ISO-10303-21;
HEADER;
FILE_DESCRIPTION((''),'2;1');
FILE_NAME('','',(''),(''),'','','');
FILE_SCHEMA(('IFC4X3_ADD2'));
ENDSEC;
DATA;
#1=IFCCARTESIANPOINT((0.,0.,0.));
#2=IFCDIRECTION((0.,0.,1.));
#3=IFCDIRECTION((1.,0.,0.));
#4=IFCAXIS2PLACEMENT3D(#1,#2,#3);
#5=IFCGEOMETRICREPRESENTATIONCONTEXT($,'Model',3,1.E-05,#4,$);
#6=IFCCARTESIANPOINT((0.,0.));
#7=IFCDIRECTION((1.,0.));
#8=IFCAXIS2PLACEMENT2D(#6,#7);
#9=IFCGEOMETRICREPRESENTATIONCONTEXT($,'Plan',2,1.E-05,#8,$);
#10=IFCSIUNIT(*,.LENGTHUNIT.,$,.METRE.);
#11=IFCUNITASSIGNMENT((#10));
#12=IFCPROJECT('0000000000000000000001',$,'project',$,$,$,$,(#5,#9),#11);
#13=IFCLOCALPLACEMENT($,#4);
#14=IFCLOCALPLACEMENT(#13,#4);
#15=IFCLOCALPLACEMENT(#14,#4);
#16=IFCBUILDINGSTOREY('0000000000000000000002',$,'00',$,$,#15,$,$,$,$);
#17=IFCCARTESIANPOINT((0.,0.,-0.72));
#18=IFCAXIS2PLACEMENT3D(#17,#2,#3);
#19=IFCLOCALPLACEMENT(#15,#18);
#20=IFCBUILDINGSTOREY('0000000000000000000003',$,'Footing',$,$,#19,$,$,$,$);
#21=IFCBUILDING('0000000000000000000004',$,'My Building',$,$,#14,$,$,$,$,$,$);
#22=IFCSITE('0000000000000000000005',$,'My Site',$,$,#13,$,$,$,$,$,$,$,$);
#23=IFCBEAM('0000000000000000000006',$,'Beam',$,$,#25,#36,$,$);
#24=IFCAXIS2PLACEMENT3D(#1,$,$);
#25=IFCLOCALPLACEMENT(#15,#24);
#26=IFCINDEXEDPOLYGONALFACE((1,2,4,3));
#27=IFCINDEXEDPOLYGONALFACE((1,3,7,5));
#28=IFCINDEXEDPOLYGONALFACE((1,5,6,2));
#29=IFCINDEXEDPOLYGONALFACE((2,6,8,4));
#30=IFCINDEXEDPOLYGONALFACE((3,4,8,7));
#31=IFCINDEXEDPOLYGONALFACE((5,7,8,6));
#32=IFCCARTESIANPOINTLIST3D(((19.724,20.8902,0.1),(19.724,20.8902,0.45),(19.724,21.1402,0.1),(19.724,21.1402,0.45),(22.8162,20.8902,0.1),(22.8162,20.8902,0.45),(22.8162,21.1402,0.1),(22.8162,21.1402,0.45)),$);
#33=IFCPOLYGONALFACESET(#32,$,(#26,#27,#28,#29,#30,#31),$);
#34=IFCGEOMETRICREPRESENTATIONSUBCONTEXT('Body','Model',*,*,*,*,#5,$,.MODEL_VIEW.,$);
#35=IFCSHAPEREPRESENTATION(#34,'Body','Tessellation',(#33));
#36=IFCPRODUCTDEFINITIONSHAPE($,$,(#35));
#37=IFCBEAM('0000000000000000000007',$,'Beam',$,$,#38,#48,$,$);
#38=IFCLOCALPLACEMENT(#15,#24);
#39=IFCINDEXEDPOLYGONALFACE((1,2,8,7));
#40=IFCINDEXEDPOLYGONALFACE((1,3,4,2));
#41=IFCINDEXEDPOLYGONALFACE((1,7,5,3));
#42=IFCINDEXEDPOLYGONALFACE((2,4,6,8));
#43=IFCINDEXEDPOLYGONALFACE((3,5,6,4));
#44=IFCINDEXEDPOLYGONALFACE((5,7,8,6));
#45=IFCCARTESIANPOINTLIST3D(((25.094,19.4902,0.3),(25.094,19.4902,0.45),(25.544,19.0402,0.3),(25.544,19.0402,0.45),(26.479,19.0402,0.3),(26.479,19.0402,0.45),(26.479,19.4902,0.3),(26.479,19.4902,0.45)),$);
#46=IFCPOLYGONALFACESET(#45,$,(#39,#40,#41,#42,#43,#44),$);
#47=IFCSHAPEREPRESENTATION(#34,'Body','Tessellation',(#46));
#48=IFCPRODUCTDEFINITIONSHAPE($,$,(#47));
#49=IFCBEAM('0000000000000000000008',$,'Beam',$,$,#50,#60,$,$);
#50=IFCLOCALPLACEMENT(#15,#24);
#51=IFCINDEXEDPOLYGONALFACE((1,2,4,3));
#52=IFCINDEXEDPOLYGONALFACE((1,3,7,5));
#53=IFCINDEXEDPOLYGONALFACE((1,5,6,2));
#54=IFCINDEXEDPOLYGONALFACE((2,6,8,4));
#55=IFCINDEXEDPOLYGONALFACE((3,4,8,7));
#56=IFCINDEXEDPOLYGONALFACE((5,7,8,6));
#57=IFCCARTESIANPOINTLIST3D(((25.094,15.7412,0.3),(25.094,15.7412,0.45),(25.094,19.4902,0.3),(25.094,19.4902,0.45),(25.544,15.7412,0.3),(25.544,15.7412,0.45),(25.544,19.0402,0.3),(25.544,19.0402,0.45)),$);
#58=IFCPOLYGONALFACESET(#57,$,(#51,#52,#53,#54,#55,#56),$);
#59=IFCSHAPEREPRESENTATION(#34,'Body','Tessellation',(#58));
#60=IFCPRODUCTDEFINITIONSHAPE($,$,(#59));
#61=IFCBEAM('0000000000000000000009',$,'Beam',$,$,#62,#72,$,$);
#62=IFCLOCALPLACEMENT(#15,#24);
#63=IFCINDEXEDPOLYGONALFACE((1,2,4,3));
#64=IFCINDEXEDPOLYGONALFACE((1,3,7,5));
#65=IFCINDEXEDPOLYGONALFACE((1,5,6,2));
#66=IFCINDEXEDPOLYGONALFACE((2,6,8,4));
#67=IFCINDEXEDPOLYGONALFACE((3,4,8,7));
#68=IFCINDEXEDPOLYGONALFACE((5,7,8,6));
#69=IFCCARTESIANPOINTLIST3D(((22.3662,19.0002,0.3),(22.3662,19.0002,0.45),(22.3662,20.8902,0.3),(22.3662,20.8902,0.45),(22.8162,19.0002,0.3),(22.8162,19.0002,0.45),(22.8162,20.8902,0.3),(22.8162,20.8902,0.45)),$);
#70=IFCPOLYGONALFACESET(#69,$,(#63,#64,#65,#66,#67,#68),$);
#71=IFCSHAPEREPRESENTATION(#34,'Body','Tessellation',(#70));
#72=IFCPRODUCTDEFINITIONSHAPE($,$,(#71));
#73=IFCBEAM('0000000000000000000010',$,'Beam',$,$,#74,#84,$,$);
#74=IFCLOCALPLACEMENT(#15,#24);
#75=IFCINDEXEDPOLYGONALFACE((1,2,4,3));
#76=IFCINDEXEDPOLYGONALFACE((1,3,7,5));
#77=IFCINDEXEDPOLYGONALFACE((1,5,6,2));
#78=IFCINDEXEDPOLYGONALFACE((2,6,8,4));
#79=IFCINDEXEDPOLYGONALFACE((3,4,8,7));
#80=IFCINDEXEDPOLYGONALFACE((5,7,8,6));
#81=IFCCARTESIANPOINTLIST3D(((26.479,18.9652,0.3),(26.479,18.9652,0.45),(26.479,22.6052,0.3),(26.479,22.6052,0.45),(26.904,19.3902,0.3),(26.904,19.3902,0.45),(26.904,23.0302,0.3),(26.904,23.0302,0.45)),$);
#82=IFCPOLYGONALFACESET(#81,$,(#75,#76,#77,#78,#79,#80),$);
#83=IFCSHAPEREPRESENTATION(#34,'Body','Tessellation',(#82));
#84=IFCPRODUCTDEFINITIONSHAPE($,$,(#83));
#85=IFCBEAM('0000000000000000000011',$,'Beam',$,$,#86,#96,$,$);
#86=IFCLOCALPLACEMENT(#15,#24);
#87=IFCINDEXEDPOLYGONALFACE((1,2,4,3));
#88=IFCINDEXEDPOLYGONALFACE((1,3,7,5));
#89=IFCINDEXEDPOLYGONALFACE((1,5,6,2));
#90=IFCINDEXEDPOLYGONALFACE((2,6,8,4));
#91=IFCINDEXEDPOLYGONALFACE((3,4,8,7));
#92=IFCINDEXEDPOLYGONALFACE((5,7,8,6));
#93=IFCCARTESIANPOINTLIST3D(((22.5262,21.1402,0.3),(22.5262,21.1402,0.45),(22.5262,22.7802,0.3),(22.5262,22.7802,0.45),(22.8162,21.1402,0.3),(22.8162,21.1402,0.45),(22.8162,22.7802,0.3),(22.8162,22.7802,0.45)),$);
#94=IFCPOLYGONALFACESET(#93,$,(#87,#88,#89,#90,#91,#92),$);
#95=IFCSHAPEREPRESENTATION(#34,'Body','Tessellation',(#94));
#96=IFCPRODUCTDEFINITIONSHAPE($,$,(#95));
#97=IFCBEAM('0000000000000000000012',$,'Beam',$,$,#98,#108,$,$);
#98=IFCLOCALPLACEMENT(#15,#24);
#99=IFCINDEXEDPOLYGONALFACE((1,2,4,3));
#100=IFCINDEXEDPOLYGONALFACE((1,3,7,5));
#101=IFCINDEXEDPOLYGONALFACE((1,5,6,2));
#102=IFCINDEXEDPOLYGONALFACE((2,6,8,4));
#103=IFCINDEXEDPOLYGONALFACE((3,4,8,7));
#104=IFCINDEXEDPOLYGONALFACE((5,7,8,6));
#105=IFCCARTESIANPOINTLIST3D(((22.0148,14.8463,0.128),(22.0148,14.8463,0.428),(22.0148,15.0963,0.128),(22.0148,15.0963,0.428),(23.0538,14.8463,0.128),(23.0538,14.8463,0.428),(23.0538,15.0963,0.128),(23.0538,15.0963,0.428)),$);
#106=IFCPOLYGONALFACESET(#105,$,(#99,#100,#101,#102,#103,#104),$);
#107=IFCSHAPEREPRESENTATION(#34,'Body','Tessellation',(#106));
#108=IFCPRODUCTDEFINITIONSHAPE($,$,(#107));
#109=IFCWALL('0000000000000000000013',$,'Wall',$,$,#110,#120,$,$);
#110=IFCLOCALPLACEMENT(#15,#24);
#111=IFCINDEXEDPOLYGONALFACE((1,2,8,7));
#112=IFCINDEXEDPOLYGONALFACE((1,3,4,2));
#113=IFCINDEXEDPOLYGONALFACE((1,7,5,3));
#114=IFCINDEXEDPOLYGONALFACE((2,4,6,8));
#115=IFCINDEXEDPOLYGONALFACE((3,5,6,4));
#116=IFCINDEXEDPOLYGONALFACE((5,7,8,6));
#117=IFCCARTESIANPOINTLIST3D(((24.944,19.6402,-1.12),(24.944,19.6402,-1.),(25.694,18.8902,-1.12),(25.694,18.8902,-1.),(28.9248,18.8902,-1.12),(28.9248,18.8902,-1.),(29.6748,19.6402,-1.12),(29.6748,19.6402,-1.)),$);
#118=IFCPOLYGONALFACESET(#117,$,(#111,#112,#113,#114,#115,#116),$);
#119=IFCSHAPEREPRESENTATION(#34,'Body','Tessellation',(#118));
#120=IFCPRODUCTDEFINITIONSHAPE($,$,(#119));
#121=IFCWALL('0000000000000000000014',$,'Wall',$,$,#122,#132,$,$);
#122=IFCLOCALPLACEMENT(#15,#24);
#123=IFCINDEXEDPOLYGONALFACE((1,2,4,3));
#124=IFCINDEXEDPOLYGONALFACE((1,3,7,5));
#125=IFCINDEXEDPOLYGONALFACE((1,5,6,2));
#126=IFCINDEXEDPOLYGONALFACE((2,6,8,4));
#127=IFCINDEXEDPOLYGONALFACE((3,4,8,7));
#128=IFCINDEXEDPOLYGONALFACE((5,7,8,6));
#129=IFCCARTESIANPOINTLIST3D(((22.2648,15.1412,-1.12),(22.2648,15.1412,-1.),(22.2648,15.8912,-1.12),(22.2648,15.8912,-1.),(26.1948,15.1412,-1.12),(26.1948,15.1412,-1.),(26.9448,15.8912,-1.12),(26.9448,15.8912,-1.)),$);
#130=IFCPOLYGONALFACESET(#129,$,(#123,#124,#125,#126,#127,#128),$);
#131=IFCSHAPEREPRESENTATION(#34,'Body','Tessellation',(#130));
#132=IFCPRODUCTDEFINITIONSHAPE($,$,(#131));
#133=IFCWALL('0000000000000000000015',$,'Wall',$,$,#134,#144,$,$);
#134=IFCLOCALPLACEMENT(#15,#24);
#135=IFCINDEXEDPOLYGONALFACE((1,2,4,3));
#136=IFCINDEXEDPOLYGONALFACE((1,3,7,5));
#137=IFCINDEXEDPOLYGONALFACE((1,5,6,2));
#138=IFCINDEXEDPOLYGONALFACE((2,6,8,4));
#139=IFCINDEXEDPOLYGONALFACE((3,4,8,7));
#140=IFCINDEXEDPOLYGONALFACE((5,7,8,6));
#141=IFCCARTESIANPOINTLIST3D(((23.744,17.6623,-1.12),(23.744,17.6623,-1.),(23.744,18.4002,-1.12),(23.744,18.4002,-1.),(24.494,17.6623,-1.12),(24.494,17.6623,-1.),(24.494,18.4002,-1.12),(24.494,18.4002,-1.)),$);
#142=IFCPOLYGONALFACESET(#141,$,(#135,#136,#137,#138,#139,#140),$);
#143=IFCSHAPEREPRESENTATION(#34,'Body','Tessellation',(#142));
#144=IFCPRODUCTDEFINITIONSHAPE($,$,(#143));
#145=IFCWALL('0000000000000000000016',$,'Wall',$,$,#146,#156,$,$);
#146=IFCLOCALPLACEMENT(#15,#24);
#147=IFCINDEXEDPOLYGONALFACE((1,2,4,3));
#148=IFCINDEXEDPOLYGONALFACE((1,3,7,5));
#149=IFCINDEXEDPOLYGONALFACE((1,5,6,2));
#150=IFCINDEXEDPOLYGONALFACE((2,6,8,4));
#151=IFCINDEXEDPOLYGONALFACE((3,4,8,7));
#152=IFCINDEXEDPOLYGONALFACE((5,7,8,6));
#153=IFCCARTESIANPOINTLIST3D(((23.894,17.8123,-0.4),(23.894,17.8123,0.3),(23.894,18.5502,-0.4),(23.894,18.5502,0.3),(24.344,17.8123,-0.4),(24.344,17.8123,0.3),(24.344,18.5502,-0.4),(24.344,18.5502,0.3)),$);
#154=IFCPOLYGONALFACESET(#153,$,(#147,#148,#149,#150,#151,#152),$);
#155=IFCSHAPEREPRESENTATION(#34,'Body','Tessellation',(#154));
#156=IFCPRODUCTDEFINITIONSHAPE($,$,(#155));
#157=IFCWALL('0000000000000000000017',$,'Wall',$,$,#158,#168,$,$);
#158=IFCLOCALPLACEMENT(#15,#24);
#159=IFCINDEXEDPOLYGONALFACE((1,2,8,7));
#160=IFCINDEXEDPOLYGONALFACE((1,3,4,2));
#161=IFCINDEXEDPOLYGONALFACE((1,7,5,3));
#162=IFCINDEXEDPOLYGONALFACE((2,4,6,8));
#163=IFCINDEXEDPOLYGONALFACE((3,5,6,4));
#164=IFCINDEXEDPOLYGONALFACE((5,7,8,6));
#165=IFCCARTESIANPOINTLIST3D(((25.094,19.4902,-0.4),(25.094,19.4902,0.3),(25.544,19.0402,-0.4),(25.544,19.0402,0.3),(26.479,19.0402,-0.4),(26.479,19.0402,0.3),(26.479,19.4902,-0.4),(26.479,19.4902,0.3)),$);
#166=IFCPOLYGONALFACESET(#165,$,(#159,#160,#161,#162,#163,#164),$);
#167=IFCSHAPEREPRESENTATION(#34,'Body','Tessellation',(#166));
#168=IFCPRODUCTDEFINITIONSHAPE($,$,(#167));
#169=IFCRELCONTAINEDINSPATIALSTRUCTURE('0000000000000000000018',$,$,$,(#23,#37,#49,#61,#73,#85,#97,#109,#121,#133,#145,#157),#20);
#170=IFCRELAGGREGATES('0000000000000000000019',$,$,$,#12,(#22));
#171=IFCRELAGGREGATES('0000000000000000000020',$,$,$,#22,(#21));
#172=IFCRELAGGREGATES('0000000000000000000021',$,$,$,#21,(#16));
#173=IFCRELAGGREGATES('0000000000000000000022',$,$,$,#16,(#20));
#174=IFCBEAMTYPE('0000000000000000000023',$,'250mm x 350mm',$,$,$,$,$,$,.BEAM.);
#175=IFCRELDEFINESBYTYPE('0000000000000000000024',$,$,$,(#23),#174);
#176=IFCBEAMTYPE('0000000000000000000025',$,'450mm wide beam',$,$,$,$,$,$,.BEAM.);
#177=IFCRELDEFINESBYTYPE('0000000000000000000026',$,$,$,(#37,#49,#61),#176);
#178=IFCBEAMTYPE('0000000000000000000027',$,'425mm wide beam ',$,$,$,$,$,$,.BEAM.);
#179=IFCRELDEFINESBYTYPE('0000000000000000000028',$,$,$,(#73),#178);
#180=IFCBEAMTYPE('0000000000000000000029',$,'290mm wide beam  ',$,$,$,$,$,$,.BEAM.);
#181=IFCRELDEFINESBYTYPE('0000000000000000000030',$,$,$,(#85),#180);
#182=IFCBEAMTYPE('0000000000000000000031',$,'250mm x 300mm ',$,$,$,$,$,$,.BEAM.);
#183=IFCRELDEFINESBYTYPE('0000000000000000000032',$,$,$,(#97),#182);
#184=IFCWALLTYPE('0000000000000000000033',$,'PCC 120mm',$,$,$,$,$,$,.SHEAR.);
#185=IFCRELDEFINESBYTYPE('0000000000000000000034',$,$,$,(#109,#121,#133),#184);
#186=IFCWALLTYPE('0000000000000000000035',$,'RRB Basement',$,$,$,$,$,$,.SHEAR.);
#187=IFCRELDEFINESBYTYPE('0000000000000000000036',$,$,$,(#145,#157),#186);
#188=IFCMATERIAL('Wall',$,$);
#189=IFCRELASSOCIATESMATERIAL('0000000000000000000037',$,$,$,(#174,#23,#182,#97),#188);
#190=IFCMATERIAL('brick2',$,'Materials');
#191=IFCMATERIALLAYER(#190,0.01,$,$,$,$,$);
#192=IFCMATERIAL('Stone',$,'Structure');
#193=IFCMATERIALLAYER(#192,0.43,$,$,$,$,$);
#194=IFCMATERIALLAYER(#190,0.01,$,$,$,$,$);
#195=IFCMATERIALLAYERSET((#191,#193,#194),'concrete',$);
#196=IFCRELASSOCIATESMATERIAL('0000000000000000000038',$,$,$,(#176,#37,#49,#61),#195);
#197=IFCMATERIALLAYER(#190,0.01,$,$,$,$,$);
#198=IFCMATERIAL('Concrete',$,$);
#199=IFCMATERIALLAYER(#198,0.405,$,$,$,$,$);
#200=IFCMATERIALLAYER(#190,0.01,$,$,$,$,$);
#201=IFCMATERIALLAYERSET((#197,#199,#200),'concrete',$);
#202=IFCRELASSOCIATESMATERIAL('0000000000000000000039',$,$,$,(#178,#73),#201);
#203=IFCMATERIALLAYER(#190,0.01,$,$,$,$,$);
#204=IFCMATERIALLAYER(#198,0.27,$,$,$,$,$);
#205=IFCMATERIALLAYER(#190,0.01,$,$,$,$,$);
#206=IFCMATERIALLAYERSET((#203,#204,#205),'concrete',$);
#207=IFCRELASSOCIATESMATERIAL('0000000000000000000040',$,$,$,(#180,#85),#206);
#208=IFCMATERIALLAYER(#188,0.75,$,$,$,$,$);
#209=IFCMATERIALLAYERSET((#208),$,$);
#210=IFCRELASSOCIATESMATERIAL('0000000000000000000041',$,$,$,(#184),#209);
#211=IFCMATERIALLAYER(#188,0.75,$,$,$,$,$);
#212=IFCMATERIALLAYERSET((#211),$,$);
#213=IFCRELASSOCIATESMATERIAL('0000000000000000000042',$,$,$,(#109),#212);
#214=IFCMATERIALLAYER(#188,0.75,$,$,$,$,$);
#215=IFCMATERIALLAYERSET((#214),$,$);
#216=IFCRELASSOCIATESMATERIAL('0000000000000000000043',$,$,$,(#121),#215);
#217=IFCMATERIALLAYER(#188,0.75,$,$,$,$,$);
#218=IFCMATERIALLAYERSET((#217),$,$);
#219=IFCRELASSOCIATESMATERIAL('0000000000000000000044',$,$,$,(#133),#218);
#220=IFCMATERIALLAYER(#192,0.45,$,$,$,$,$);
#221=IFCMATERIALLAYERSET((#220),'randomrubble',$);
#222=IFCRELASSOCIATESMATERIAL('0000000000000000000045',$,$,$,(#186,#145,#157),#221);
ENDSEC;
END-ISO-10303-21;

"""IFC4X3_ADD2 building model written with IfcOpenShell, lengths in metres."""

from ifc_helpers import new_model, si_unit, frame, origin_with_axes, origin_2d_with_axis, place, context, subcontext, project, spatial, line, indexed_curve, rectangle, outline, extrude, material, layer, layer_set, layer_usage, material_profile, profile_set, profile_usage, type_object, element, save


model = new_model("IFC4X3_ADD2")

# Units and contexts
model_context = context("Model", 3, precision=1e-05, world=origin_with_axes())
plan_context = context("Plan", 2, precision=1e-05, world=origin_2d_with_axis())
body_context = subcontext(model_context, "Body", "Model", "MODEL_VIEW")
ifc_project = project(units=[si_unit("LENGTHUNIT", "METRE")], contexts=[model_context, plan_context])

# Site, building, storeys
site_placement = place(None, origin_with_axes())
site = spatial("IfcSite", under=ifc_project, at=site_placement, Name="My Site")
building_placement = place(site_placement, origin_with_axes())
building = spatial("IfcBuilding", under=site, at=building_placement, Name="My Building")
storey_1_placement = place(building_placement, origin_with_axes())
storey_1 = spatial("IfcBuildingStorey", under=building, at=storey_1_placement, Name="00")
storey_2_placement = place(storey_1_placement, frame((0.0, 0.0, -0.72), z_axis=(0.0, 0.0, 1.0), x_axis=(1.0, 0.0, 0.0)))
storey_2 = spatial("IfcBuildingStorey", under=storey_1, at=storey_2_placement, Name="Footing")

# Beams
ifc_material_1 = material(Name="Wall")
ifc_material_profile_1 = material_profile(ifc_material_1, rectangle(XDim=0.25, YDim=0.35))
ifc_profile_set_1 = profile_set([ifc_material_profile_1], Name="concrete")
ifc_profile_usage_1 = profile_usage(ifc_profile_set_1, cardinal=5)
beam_type_1 = type_object("IfcBeamType", Name="250mm x 350mm", PredefinedType="BEAM", material=ifc_profile_set_1)
beam_1_placement = place(storey_2_placement, frame((22.8162, 21.0152, 0.995), z_axis=(-1.0, -0.000001, 0.000001), x_axis=(0.000001, -1.0, 0.0)))
element("IfcBeam", 1, at=beam_1_placement, inside=storey_2, type_object=beam_type_1, material=ifc_profile_usage_1, Name="Beam", context=body_context, shape_type="SweptSolid", body=[
    extrude(rectangle(XDim=0.25, YDim=0.35), origin_with_axes(), (0.0, 0.0, 1.0), 3.0922),
])
ifc_material_2 = material(Name="brick2", Category="Materials")
ifc_layer_1 = layer(ifc_material_2, 0.01)
ifc_material_3 = material(Name="Stone", Category="Structure")
ifc_layer_2 = layer(ifc_material_3, 0.43)
ifc_layer_3 = layer(ifc_material_2, 0.01)
ifc_layer_set_1 = layer_set([ifc_layer_1, ifc_layer_2, ifc_layer_3], Name="concrete")
ifc_layer_usage_1 = layer_usage(ifc_layer_set_1, "AXIS2", "NEGATIVE", 0.0)
beam_type_2 = type_object("IfcBeamType", Name="450mm wide beam", PredefinedType="BEAM", material=ifc_layer_set_1)
beam_2_placement = place(storey_2_placement, frame((25.544, 19.4902, 1.02), z_axis=(0.0, 0.0, 1.0), x_axis=(1.0, 0.0, 0.0)))
element("IfcBeam", 2, at=beam_2_placement, inside=storey_2, type_object=beam_type_2, material=ifc_layer_usage_1, Name="Beam", context=body_context, shape_type="SweptSolid", body=[
    extrude(outline(indexed_curve([(0.0, -0.45), (-0.45, 0.0), (0.935, 0.0), (0.935, -0.45)], segments=[line(1, 2, 3, 4, 1)])), origin_with_axes(), (0.0, 0.0, 1.0), 0.15),
])
ifc_layer_usage_2 = layer_usage(ifc_layer_set_1, "AXIS2", "NEGATIVE", 0.0)
beam_3_placement = place(storey_2_placement, frame((25.544, 19.4902, 1.02), z_axis=(0.0, 0.0, 1.0), x_axis=(0.0, -1.0, 0.0)))
element("IfcBeam", 3, at=beam_3_placement, inside=storey_2, type_object=beam_type_2, material=ifc_layer_usage_2, Name="Beam", context=body_context, shape_type="SweptSolid", body=[
    extrude(outline(indexed_curve([(0.0, -0.45), (0.45, 0.0), (3.749, 0.0), (3.749, -0.45)], segments=[line(1, 2, 3, 4, 1)])), origin_with_axes(), (0.0, 0.0, 1.0), 0.15),
])
ifc_layer_usage_3 = layer_usage(ifc_layer_set_1, "AXIS2", "POSITIVE", 0.0)
beam_4_placement = place(storey_2_placement, frame((22.3662, 20.8902, 1.02), z_axis=(0.0, 0.0, 1.0), x_axis=(0.0, -1.0, 0.0)))
element("IfcBeam", 4, at=beam_4_placement, inside=storey_2, type_object=beam_type_2, material=ifc_layer_usage_3, Name="Beam", context=body_context, shape_type="SweptSolid", body=[
    extrude(outline(indexed_curve([(0.0, 0.0), (0.0, 0.45), (1.89, 0.45), (1.89, 0.0)], segments=[line(1, 2, 3, 4, 1)])), origin_with_axes(), (0.0, 0.0, 1.0), 0.15),
])
ifc_layer_4 = layer(ifc_material_2, 0.01)
ifc_material_4 = material(Name="Concrete")
ifc_layer_5 = layer(ifc_material_4, 0.405)
ifc_layer_6 = layer(ifc_material_2, 0.01)
ifc_layer_set_2 = layer_set([ifc_layer_4, ifc_layer_5, ifc_layer_6], Name="concrete")
ifc_layer_usage_4 = layer_usage(ifc_layer_set_2, "AXIS2", "POSITIVE", 0.0)
beam_type_3 = type_object("IfcBeamType", Name="425mm wide beam ", PredefinedType="BEAM", material=ifc_layer_set_2)
beam_5_placement = place(storey_2_placement, frame((26.479, 22.6052, 1.02), z_axis=(0.0, 0.0, 1.0), x_axis=(0.0, -1.0, 0.0)))
element("IfcBeam", 5, at=beam_5_placement, inside=storey_2, type_object=beam_type_3, material=ifc_layer_usage_4, Name="Beam", context=body_context, shape_type="SweptSolid", body=[
    extrude(outline(indexed_curve([(0.0, 0.0), (-0.425, 0.425), (3.215, 0.425), (3.64, 0.0)], segments=[line(1, 2, 3, 4, 1)])), origin_with_axes(), (0.0, 0.0, 1.0), 0.15),
])
ifc_layer_7 = layer(ifc_material_2, 0.01)
ifc_layer_8 = layer(ifc_material_4, 0.27)
ifc_layer_9 = layer(ifc_material_2, 0.01)
ifc_layer_set_3 = layer_set([ifc_layer_7, ifc_layer_8, ifc_layer_9], Name="concrete")
ifc_layer_usage_5 = layer_usage(ifc_layer_set_3, "AXIS2", "POSITIVE", 0.0)
beam_type_4 = type_object("IfcBeamType", Name="290mm wide beam  ", PredefinedType="BEAM", material=ifc_layer_set_3)
beam_6_placement = place(storey_2_placement, frame((22.5262, 22.7802, 1.02), z_axis=(0.0, 0.0, 1.0), x_axis=(0.0, -1.0, 0.0)))
element("IfcBeam", 6, at=beam_6_placement, inside=storey_2, type_object=beam_type_4, material=ifc_layer_usage_5, Name="Beam", context=body_context, shape_type="SweptSolid", body=[
    extrude(outline(indexed_curve([(0.0, 0.0), (0.0, 0.29), (1.64, 0.29), (1.64, 0.0)], segments=[line(1, 2, 3, 4, 1)])), origin_with_axes(), (0.0, 0.0, 1.0), 0.15),
])
ifc_material_profile_2 = material_profile(ifc_material_1, rectangle(XDim=0.25, YDim=0.3))
ifc_profile_set_2 = profile_set([ifc_material_profile_2], Name="concrete")
ifc_profile_usage_2 = profile_usage(ifc_profile_set_2)
beam_type_5 = type_object("IfcBeamType", Name="250mm x 300mm ", PredefinedType="BEAM", material=ifc_profile_set_2)
beam_7_placement = place(storey_2_placement, frame((23.0538, 14.9713, 0.998), z_axis=(-1.0, -0.000001, 0.000001), x_axis=(0.000001, -1.0, 0.0)))
element("IfcBeam", 7, at=beam_7_placement, inside=storey_2, type_object=beam_type_5, material=ifc_profile_usage_2, Name="Beam", context=body_context, shape_type="SweptSolid", body=[
    extrude(rectangle(XDim=0.25, YDim=0.3), origin_with_axes(), (0.0, 0.0, 1.0), 1.039),
])

# Walls
ifc_layer_10 = layer(ifc_material_1, 0.75)
ifc_layer_set_4 = layer_set([ifc_layer_10])
ifc_layer_usage_6 = layer_usage(ifc_layer_set_4, "AXIS2", "POSITIVE", 0.0)
ifc_layer_11 = layer(ifc_material_1, 0.75)
ifc_layer_set_5 = layer_set([ifc_layer_11])
wall_type_1 = type_object("IfcWallType", Name="PCC 120mm", PredefinedType="SHEAR", material=ifc_layer_set_5)
wall_1_placement = place(storey_2_placement, frame((25.694, 18.8902, -0.4), z_axis=(0.0, 0.0, 1.0), x_axis=(1.0, 0.0, 0.0)))
element("IfcWall", 8, at=wall_1_placement, inside=storey_2, type_object=wall_type_1, material=ifc_layer_usage_6, Name="Wall", context=body_context, shape_type="SweptSolid", body=[
    extrude(outline(indexed_curve([(0.0, 0.0), (-0.75, 0.75), (3.9808, 0.75), (3.2308, 0.0)], segments=[line(1, 2, 3, 4, 1)])), origin_with_axes(), (0.0, 0.0, 1.0), 0.12),
])
ifc_layer_12 = layer(ifc_material_1, 0.75)
ifc_layer_set_6 = layer_set([ifc_layer_12])
ifc_layer_usage_7 = layer_usage(ifc_layer_set_6, "AXIS2", "POSITIVE", 0.0)
wall_2_placement = place(storey_2_placement, frame((22.2648, 15.1412, -0.4), z_axis=(0.0, 0.0, 1.0), x_axis=(1.0, 0.0, 0.0)))
element("IfcWall", 9, at=wall_2_placement, inside=storey_2, type_object=wall_type_1, material=ifc_layer_usage_7, Name="Wall", context=body_context, shape_type="SweptSolid", body=[
    extrude(outline(indexed_curve([(0.0, 0.0), (0.0, 0.75), (4.68, 0.75), (3.93, 0.0)], segments=[line(1, 2, 3, 4, 1)])), origin_with_axes(), (0.0, 0.0, 1.0), 0.12),
])
ifc_layer_13 = layer(ifc_material_1, 0.75)
ifc_layer_set_7 = layer_set([ifc_layer_13])
ifc_layer_usage_8 = layer_usage(ifc_layer_set_7, "AXIS2", "NEGATIVE", 0.0)
wall_3_placement = place(storey_2_placement, frame((23.744, 17.6623, -0.4), z_axis=(0.0, 0.0, 1.0), x_axis=(0.000001, 1.0, 0.0)))
element("IfcWall", 10, at=wall_3_placement, inside=storey_2, type_object=wall_type_1, material=ifc_layer_usage_8, Name="Wall", context=body_context, shape_type="SweptSolid", body=[
    extrude(outline(indexed_curve([(0.0, -0.75), (0.0, 0.0), (0.7379, 0.0), (0.7379, -0.75)], segments=[line(1, 2, 3, 4, 1)])), origin_with_axes(), (0.0, 0.0, 1.0), 0.12),
])
ifc_layer_14 = layer(ifc_material_3, 0.45)
ifc_layer_set_8 = layer_set([ifc_layer_14], Name="randomrubble")
wall_type_2 = type_object("IfcWallType", Name="RRB Basement", PredefinedType="SHEAR", material=ifc_layer_set_8)
ifc_layer_usage_9 = layer_usage(ifc_layer_set_8, "AXIS2", "POSITIVE", 0.0)
wall_4_placement = place(storey_2_placement, frame((24.344, 17.8123, 0.32), z_axis=(0.0, 0.0, 1.0), x_axis=(0.000001, 1.0, 0.0)))
element("IfcWall", 11, at=wall_4_placement, inside=storey_2, type_object=wall_type_2, material=ifc_layer_usage_9, Name="Wall", context=body_context, shape_type="SweptSolid", body=[
    extrude(outline(indexed_curve([(0.0, 0.0), (0.0, 0.45), (0.7379, 0.45), (0.7379, 0.0)], segments=[line(1, 2, 3, 4, 1)])), origin_with_axes(), (0.0, 0.0, 1.0), 0.7),
])
ifc_layer_usage_10 = layer_usage(ifc_layer_set_8, "AXIS2", "POSITIVE", 0.0)
wall_5_placement = place(storey_2_placement, frame((25.094, 19.0402, 0.32), z_axis=(0.0, 0.0, 1.0), x_axis=(1.0, 0.0, 0.0)))
element("IfcWall", 12, at=wall_5_placement, inside=storey_2, type_object=wall_type_2, material=ifc_layer_usage_10, Name="Wall", context=body_context, shape_type="SweptSolid", body=[
    extrude(outline(indexed_curve([(0.45, 0.0), (0.0, 0.45), (1.385, 0.45), (1.385, 0.0)], segments=[line(1, 2, 3, 4, 1)])), origin_with_axes(), (0.0, 0.0, 1.0), 0.7),
])

save(model, "model.ifc")
